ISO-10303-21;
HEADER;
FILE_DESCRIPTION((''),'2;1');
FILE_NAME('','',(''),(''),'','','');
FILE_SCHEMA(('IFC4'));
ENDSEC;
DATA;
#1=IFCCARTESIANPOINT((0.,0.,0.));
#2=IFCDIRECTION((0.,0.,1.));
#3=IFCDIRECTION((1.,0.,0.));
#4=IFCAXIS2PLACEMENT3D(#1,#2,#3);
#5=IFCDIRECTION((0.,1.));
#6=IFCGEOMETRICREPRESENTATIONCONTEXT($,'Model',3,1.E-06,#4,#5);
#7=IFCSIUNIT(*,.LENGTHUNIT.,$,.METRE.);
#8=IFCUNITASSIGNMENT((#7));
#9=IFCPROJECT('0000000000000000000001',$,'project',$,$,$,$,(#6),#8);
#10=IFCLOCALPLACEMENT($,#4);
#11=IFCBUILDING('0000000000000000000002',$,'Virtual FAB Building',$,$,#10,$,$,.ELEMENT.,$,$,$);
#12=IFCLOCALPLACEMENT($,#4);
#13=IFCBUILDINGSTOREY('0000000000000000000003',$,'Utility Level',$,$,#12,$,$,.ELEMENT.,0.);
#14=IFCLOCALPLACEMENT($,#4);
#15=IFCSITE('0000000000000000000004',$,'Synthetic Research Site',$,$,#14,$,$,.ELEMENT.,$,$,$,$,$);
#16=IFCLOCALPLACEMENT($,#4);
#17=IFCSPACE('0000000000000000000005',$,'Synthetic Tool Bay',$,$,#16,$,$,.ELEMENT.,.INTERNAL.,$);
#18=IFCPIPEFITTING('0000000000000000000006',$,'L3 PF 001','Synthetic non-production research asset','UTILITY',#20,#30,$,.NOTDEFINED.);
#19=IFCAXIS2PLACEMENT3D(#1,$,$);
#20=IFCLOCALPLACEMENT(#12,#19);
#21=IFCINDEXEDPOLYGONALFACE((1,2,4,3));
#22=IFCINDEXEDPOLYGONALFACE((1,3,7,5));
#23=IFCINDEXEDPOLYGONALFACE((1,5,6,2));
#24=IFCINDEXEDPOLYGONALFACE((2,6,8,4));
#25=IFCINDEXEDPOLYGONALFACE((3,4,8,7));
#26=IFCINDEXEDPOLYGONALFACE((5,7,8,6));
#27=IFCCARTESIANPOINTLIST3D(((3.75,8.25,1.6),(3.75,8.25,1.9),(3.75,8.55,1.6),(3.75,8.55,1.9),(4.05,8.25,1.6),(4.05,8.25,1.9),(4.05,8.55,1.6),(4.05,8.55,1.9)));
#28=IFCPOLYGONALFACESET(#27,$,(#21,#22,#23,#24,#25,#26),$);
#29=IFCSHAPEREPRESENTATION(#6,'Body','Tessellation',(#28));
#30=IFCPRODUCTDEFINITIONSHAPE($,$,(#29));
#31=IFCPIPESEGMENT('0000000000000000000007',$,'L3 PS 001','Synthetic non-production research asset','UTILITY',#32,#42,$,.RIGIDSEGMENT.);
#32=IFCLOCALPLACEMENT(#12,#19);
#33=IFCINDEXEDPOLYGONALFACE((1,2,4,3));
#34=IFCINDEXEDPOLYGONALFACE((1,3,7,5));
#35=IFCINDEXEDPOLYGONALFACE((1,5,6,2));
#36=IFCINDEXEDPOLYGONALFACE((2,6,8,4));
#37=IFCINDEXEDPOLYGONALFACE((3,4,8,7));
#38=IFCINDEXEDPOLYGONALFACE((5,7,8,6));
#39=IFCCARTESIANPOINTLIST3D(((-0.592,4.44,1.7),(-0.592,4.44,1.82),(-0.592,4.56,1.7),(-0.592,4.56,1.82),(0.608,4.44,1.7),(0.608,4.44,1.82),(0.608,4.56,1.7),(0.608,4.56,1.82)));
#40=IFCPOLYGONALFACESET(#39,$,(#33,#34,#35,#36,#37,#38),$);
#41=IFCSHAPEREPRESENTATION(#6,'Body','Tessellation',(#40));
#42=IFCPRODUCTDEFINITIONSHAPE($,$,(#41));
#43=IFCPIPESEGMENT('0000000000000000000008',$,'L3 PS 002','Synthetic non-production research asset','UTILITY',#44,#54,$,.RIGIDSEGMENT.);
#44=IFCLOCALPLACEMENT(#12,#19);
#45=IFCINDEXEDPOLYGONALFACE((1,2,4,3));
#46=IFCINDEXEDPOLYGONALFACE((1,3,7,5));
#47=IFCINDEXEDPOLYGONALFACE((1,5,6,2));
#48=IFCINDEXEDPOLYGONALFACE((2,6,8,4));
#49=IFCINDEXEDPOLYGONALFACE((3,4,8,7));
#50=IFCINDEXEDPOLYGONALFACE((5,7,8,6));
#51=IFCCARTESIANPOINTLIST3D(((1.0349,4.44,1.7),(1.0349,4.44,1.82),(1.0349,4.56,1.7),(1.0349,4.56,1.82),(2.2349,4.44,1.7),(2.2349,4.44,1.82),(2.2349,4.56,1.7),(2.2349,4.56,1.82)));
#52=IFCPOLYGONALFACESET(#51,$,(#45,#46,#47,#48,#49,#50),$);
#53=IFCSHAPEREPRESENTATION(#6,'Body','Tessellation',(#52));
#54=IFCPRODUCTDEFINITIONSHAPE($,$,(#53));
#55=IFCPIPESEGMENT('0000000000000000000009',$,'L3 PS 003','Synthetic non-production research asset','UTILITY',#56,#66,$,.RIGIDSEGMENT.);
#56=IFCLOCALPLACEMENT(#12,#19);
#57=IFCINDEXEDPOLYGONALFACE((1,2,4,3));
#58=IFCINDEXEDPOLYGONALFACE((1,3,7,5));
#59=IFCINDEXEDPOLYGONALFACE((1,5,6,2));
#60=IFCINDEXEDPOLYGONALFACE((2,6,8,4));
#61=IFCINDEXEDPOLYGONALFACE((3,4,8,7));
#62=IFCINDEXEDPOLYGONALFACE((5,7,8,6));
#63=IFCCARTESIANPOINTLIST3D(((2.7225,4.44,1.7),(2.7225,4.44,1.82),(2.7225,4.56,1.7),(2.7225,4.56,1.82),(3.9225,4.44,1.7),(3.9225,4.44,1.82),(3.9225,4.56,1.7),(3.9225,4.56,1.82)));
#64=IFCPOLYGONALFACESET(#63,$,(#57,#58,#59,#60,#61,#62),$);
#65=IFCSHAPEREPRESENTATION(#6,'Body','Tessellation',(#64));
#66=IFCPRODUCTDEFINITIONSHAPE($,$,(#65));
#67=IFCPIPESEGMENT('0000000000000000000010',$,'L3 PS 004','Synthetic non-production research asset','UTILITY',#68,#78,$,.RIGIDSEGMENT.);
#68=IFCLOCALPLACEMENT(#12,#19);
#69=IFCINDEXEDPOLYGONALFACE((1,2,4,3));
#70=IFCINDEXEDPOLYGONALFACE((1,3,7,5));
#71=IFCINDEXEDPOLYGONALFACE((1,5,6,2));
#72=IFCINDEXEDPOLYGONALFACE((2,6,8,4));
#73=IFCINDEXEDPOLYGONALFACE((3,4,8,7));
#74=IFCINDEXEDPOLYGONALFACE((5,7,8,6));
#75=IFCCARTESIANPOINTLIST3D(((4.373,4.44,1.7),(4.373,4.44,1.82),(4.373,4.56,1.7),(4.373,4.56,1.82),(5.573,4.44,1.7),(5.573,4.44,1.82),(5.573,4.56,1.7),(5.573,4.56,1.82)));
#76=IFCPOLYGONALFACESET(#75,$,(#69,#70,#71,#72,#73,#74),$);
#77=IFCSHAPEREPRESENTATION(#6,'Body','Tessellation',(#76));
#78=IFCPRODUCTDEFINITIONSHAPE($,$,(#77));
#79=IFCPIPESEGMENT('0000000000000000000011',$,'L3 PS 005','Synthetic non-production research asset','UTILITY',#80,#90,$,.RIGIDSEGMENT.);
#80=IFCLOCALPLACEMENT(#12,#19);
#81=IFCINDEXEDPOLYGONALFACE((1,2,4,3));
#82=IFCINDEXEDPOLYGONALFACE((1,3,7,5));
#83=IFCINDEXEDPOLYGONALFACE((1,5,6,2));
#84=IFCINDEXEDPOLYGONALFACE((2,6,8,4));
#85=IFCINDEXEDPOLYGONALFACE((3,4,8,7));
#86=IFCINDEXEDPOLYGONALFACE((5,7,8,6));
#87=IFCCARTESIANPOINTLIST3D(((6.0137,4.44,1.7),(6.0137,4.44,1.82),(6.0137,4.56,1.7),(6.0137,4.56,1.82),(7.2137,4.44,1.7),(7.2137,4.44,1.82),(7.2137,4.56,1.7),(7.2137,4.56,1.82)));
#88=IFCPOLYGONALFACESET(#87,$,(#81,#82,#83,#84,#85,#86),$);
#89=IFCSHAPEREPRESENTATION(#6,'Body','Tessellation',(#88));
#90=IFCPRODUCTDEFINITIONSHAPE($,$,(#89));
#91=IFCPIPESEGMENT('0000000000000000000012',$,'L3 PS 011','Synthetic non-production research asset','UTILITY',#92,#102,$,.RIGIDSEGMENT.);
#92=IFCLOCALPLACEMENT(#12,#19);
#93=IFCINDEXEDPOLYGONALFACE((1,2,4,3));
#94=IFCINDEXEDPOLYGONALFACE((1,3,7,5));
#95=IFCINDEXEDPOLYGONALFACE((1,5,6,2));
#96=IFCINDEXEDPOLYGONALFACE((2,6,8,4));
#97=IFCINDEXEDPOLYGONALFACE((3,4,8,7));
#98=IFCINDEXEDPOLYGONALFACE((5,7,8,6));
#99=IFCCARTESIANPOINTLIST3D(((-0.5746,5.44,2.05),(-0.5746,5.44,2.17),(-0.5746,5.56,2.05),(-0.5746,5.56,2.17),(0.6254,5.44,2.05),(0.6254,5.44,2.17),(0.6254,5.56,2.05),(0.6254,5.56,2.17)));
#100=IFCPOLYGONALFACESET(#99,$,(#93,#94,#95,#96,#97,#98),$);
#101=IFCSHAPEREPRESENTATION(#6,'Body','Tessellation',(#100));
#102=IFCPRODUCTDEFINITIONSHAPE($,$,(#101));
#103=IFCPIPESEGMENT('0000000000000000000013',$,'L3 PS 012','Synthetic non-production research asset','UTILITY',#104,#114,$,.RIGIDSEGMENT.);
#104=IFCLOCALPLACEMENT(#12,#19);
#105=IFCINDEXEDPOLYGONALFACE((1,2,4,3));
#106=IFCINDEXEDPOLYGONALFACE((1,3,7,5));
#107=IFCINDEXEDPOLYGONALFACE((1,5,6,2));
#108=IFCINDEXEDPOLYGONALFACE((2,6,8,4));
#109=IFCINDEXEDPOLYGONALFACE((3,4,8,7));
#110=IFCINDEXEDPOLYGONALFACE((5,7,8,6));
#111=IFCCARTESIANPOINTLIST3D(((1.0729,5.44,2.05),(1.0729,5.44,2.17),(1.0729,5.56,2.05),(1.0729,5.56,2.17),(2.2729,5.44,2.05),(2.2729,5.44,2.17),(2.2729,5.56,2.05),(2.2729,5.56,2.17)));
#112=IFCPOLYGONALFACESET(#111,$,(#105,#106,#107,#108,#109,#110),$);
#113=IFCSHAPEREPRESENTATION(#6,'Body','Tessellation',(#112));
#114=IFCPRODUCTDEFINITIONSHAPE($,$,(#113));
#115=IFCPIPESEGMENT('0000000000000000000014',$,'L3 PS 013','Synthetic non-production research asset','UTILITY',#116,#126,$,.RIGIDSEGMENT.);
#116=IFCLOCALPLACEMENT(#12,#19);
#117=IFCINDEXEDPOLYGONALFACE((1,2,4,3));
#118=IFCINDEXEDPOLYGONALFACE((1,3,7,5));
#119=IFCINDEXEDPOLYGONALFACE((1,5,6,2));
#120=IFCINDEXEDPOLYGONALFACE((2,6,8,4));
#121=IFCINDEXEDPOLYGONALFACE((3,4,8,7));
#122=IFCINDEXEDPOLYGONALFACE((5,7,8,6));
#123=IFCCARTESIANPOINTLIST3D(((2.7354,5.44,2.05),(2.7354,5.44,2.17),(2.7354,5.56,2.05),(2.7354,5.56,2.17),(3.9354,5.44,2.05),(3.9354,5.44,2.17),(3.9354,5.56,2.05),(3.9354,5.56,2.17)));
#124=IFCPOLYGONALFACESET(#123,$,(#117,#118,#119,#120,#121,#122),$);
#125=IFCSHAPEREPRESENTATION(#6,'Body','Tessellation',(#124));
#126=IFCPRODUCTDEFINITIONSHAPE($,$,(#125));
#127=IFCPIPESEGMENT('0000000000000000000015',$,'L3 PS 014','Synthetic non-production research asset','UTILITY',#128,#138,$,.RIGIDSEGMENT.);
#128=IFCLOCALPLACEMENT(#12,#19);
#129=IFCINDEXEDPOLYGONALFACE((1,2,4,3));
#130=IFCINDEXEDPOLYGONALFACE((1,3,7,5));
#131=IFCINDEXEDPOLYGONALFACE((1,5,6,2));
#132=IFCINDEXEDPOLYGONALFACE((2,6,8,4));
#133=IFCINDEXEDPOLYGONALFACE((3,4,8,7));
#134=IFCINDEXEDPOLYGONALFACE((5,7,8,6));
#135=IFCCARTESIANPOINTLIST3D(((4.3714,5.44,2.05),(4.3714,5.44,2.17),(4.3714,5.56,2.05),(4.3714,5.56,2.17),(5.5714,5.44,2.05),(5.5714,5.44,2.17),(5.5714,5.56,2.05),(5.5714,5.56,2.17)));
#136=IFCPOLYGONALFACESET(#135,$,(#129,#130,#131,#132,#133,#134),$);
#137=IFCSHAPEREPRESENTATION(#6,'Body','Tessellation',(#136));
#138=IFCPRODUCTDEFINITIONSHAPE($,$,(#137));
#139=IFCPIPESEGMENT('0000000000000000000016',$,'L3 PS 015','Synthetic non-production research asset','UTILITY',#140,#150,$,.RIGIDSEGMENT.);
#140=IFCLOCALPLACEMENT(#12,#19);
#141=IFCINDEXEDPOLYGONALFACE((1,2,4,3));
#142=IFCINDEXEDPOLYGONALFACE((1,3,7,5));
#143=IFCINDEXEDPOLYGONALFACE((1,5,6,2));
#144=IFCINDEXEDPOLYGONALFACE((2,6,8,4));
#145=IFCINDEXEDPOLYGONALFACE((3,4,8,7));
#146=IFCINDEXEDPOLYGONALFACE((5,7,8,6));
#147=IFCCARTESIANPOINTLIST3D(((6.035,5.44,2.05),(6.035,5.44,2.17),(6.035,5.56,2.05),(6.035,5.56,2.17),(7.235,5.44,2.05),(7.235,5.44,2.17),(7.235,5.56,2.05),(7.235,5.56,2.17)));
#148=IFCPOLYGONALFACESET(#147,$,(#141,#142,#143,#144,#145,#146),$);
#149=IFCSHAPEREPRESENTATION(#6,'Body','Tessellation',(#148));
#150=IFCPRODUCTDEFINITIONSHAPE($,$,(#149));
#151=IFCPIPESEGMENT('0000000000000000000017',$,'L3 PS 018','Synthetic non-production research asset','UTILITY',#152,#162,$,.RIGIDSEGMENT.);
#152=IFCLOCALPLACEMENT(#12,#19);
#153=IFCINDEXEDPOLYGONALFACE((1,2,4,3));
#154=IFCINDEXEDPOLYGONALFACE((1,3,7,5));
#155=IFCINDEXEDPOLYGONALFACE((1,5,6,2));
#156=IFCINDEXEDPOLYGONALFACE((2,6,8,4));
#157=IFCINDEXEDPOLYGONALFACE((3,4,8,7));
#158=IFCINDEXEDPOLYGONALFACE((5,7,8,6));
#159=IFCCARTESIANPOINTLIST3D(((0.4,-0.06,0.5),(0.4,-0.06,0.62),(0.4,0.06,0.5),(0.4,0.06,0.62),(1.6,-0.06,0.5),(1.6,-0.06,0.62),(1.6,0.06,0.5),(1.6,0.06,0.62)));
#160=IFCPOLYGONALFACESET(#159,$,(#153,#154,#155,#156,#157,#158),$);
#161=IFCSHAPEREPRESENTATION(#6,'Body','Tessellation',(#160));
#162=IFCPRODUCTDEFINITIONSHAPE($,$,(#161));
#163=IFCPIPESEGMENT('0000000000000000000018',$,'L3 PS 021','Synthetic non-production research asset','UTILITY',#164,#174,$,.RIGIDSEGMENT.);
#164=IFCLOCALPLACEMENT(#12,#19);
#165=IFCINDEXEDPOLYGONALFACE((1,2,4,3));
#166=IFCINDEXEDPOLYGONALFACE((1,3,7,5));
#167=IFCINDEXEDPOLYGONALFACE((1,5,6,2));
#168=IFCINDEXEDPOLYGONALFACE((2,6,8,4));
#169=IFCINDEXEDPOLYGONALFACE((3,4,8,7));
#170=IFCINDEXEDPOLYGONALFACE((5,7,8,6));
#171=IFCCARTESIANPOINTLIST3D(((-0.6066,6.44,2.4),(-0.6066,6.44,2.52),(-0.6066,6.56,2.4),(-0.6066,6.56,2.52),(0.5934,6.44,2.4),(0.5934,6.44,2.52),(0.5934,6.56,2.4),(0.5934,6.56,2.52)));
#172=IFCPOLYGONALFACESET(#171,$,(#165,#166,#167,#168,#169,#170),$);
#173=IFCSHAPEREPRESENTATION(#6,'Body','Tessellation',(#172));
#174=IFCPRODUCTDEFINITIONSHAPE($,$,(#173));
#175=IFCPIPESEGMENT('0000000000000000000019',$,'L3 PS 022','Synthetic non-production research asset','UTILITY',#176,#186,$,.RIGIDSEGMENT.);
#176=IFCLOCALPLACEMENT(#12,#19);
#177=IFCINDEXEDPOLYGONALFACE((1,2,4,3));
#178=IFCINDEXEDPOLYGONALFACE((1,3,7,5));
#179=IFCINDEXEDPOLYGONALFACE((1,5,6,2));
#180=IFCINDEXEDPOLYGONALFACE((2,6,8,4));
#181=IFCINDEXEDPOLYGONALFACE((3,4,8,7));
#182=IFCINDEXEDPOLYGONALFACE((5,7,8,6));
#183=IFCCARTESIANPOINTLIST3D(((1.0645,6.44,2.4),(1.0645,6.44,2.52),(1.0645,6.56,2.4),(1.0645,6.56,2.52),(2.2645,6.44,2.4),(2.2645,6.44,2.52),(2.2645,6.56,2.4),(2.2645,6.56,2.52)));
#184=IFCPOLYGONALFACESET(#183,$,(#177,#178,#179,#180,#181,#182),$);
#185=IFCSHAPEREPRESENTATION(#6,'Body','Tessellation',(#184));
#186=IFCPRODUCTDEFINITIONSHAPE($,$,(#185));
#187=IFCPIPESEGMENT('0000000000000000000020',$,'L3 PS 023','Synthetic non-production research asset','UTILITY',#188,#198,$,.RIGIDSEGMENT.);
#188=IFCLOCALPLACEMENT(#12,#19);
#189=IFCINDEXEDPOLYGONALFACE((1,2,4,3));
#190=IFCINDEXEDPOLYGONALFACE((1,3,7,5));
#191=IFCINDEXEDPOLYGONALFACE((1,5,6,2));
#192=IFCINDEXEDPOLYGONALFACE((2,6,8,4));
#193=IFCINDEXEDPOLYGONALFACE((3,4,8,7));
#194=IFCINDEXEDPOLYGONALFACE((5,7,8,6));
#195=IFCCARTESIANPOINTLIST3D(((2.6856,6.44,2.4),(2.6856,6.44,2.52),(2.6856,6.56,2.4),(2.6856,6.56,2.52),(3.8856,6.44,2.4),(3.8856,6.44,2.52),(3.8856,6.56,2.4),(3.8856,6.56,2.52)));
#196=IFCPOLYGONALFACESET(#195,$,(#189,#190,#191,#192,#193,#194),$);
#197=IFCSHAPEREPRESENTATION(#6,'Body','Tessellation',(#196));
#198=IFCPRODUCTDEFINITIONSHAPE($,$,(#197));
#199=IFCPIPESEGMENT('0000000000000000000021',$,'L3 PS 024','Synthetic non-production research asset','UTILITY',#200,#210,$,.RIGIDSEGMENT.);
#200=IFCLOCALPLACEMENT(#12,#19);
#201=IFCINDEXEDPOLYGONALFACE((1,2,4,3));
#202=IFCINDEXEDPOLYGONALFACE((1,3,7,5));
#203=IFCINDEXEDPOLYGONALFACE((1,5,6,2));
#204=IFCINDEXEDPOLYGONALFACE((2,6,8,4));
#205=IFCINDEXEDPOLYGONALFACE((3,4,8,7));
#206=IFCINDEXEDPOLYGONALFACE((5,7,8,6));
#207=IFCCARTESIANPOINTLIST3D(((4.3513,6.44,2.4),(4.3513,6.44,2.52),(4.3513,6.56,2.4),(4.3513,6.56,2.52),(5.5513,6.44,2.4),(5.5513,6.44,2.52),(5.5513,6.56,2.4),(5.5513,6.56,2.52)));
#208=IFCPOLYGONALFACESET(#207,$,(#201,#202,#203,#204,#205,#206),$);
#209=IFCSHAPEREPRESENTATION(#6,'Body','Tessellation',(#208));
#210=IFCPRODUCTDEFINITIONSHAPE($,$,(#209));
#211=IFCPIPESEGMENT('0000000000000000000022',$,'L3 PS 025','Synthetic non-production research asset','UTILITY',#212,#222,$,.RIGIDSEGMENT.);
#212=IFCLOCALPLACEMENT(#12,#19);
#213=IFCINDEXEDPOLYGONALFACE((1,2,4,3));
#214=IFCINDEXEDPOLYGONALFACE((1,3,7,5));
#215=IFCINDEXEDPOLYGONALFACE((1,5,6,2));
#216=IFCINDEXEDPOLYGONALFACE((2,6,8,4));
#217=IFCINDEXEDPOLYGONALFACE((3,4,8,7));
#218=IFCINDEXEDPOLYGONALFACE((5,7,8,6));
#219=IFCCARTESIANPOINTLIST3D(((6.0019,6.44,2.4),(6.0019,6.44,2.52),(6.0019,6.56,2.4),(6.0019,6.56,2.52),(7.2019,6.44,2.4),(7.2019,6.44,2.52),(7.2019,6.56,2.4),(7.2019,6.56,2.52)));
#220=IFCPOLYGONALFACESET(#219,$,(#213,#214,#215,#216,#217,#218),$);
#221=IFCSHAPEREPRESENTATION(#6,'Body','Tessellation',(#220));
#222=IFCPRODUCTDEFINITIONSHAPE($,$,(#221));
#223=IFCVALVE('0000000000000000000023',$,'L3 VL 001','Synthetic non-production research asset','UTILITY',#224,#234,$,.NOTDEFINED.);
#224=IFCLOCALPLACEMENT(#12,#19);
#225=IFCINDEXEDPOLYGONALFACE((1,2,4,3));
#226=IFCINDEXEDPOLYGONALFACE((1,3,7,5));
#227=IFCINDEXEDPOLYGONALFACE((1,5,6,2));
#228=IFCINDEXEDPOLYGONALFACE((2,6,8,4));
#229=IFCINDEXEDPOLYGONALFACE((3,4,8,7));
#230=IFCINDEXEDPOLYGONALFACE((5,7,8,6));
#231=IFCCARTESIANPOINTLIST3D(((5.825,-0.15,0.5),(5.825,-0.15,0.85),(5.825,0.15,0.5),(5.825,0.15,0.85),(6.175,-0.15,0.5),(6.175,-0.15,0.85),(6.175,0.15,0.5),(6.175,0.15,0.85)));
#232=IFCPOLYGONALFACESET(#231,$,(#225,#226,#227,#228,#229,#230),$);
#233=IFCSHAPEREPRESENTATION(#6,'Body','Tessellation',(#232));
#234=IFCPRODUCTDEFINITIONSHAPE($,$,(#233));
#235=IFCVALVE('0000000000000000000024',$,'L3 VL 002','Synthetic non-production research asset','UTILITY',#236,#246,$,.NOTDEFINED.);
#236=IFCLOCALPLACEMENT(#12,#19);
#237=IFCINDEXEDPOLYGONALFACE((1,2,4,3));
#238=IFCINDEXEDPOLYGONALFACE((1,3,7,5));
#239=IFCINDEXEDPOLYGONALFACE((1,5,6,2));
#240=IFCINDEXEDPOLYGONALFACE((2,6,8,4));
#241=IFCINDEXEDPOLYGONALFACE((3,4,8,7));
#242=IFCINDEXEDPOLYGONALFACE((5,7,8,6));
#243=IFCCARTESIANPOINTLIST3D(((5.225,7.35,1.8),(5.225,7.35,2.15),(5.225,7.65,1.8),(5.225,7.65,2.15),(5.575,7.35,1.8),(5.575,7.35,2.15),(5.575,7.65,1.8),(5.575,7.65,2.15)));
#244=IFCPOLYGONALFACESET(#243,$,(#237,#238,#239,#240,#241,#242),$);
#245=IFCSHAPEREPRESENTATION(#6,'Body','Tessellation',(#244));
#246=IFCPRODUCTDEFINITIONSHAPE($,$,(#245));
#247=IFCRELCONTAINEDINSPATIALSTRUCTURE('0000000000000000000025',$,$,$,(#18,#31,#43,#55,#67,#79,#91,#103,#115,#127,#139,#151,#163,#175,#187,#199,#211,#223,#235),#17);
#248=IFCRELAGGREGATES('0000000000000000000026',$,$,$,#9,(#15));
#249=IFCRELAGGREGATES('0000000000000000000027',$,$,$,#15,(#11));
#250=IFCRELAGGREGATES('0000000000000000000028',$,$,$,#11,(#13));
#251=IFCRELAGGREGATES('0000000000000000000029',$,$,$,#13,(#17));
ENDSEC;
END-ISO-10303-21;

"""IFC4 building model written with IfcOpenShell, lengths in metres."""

from ifc_helpers import new_model, si_unit, direction, frame, origin_with_axes, origin_2d_with_axis, place, context, project, spatial, rectangle, extrude, element, save


model = new_model("IFC4")

# Units and contexts
model_context = context("Model", 3, precision=1e-06, world=origin_with_axes(), true_north=direction((0.0, 1.0)))
ifc_project = project(units=[si_unit("LENGTHUNIT", "METRE")], contexts=[model_context])

# Site, building, storey, space
site_placement = place(None, origin_with_axes())
site = spatial("IfcSite", under=ifc_project, at=site_placement, Name="Synthetic Research Site", CompositionType="ELEMENT")
building_placement = place(None, origin_with_axes())
building = spatial("IfcBuilding", under=site, at=building_placement, Name="Virtual FAB Building", CompositionType="ELEMENT")
storey_placement = place(None, origin_with_axes())
storey = spatial("IfcBuildingStorey", under=building, at=storey_placement, Name="Utility Level", CompositionType="ELEMENT", Elevation=0.0)
space_placement = place(None, origin_with_axes())
space = spatial("IfcSpace", under=storey, at=space_placement, Name="Synthetic Tool Bay", CompositionType="ELEMENT", PredefinedType="INTERNAL")

# Pipe fitting
pipe_fitting_placement = place(None, frame((3.9, 8.4, 1.6), z_axis=(0.0, 0.0, 1.0), x_axis=(1.0, 0.0, 0.0)))
element("IfcPipeFitting", 1, at=pipe_fitting_placement, inside=space, Name="L3 PF 001", Description="Synthetic non-production research asset", ObjectType="UTILITY", PredefinedType="NOTDEFINED", context=model_context, shape_type="SweptSolid", body=[
    extrude(rectangle(XDim=0.3, YDim=0.3, at=origin_2d_with_axis()), origin_with_axes(), (0.0, 0.0, 1.0), 0.3),
])

# Pipe segments
for number, where, z_axis, x_axis, name in (
    (2, (0.008, 4.5, 1.7), (0.0, 0.0, 1.0), (1.0, 0.0, 0.0), "L3 PS 001"),
    (3, (1.6349, 4.5, 1.7), (0.0, 0.0, 1.0), (1.0, 0.0, 0.0), "L3 PS 002"),
    (4, (3.3225, 4.5, 1.7), (0.0, 0.0, 1.0), (1.0, 0.0, 0.0), "L3 PS 003"),
    (5, (4.973, 4.5, 1.7), (0.0, 0.0, 1.0), (1.0, 0.0, 0.0), "L3 PS 004"),
    (6, (6.6137, 4.5, 1.7), (0.0, 0.0, 1.0), (1.0, 0.0, 0.0), "L3 PS 005"),
    (7, (0.0254, 5.5, 2.05), (0.0, 0.0, 1.0), (1.0, 0.0, 0.0), "L3 PS 011"),
    (8, (1.6729, 5.5, 2.05), (0.0, 0.0, 1.0), (1.0, 0.0, 0.0), "L3 PS 012"),
    (9, (3.3354, 5.5, 2.05), (0.0, 0.0, 1.0), (1.0, 0.0, 0.0), "L3 PS 013"),
    (10, (4.9714, 5.5, 2.05), (0.0, 0.0, 1.0), (1.0, 0.0, 0.0), "L3 PS 014"),
    (11, (6.635, 5.5, 2.05), (0.0, 0.0, 1.0), (1.0, 0.0, 0.0), "L3 PS 015"),
    (12, (1.0, 0.0, 0.5), (0.0, 0.0, 1.0), (1.0, 0.0, 0.0), "L3 PS 018"),
    (13, (-0.0066, 6.5, 2.4), (0.0, 0.0, 1.0), (1.0, 0.0, 0.0), "L3 PS 021"),
    (14, (1.6645, 6.5, 2.4), (0.0, 0.0, 1.0), (1.0, 0.0, 0.0), "L3 PS 022"),
    (15, (3.2856, 6.5, 2.4), (0.0, 0.0, 1.0), (1.0, 0.0, 0.0), "L3 PS 023"),
    (16, (4.9513, 6.5, 2.4), (0.0, 0.0, 1.0), (1.0, 0.0, 0.0), "L3 PS 024"),
    (17, (6.6019, 6.5, 2.4), (0.0, 0.0, 1.0), (1.0, 0.0, 0.0), "L3 PS 025"),
):
    element("IfcPipeSegment", number, at=place(None, frame(where, z_axis=z_axis, x_axis=x_axis)), inside=space, Name=name, Description="Synthetic non-production research asset", ObjectType="UTILITY", PredefinedType="RIGIDSEGMENT", context=model_context, shape_type="SweptSolid", body=[
        extrude(rectangle(XDim=1.2, YDim=0.12, at=origin_2d_with_axis()), origin_with_axes(), (0.0, 0.0, 1.0), 0.12),
    ])

# Valves
for number, where, z_axis, x_axis, name in (
    (18, (6.0, 0.0, 0.5), (0.0, 0.0, 1.0), (1.0, 0.0, 0.0), "L3 VL 001"),
    (19, (5.4, 7.5, 1.8), (0.0, 0.0, 1.0), (1.0, 0.0, 0.0), "L3 VL 002"),
):
    element("IfcValve", number, at=place(None, frame(where, z_axis=z_axis, x_axis=x_axis)), inside=space, Name=name, Description="Synthetic non-production research asset", ObjectType="UTILITY", PredefinedType="NOTDEFINED", context=model_context, shape_type="SweptSolid", body=[
        extrude(rectangle(XDim=0.35, YDim=0.3, at=origin_2d_with_axis()), origin_with_axes(), (0.0, 0.0, 1.0), 0.35),
    ])

save(model, "model.ifc")
